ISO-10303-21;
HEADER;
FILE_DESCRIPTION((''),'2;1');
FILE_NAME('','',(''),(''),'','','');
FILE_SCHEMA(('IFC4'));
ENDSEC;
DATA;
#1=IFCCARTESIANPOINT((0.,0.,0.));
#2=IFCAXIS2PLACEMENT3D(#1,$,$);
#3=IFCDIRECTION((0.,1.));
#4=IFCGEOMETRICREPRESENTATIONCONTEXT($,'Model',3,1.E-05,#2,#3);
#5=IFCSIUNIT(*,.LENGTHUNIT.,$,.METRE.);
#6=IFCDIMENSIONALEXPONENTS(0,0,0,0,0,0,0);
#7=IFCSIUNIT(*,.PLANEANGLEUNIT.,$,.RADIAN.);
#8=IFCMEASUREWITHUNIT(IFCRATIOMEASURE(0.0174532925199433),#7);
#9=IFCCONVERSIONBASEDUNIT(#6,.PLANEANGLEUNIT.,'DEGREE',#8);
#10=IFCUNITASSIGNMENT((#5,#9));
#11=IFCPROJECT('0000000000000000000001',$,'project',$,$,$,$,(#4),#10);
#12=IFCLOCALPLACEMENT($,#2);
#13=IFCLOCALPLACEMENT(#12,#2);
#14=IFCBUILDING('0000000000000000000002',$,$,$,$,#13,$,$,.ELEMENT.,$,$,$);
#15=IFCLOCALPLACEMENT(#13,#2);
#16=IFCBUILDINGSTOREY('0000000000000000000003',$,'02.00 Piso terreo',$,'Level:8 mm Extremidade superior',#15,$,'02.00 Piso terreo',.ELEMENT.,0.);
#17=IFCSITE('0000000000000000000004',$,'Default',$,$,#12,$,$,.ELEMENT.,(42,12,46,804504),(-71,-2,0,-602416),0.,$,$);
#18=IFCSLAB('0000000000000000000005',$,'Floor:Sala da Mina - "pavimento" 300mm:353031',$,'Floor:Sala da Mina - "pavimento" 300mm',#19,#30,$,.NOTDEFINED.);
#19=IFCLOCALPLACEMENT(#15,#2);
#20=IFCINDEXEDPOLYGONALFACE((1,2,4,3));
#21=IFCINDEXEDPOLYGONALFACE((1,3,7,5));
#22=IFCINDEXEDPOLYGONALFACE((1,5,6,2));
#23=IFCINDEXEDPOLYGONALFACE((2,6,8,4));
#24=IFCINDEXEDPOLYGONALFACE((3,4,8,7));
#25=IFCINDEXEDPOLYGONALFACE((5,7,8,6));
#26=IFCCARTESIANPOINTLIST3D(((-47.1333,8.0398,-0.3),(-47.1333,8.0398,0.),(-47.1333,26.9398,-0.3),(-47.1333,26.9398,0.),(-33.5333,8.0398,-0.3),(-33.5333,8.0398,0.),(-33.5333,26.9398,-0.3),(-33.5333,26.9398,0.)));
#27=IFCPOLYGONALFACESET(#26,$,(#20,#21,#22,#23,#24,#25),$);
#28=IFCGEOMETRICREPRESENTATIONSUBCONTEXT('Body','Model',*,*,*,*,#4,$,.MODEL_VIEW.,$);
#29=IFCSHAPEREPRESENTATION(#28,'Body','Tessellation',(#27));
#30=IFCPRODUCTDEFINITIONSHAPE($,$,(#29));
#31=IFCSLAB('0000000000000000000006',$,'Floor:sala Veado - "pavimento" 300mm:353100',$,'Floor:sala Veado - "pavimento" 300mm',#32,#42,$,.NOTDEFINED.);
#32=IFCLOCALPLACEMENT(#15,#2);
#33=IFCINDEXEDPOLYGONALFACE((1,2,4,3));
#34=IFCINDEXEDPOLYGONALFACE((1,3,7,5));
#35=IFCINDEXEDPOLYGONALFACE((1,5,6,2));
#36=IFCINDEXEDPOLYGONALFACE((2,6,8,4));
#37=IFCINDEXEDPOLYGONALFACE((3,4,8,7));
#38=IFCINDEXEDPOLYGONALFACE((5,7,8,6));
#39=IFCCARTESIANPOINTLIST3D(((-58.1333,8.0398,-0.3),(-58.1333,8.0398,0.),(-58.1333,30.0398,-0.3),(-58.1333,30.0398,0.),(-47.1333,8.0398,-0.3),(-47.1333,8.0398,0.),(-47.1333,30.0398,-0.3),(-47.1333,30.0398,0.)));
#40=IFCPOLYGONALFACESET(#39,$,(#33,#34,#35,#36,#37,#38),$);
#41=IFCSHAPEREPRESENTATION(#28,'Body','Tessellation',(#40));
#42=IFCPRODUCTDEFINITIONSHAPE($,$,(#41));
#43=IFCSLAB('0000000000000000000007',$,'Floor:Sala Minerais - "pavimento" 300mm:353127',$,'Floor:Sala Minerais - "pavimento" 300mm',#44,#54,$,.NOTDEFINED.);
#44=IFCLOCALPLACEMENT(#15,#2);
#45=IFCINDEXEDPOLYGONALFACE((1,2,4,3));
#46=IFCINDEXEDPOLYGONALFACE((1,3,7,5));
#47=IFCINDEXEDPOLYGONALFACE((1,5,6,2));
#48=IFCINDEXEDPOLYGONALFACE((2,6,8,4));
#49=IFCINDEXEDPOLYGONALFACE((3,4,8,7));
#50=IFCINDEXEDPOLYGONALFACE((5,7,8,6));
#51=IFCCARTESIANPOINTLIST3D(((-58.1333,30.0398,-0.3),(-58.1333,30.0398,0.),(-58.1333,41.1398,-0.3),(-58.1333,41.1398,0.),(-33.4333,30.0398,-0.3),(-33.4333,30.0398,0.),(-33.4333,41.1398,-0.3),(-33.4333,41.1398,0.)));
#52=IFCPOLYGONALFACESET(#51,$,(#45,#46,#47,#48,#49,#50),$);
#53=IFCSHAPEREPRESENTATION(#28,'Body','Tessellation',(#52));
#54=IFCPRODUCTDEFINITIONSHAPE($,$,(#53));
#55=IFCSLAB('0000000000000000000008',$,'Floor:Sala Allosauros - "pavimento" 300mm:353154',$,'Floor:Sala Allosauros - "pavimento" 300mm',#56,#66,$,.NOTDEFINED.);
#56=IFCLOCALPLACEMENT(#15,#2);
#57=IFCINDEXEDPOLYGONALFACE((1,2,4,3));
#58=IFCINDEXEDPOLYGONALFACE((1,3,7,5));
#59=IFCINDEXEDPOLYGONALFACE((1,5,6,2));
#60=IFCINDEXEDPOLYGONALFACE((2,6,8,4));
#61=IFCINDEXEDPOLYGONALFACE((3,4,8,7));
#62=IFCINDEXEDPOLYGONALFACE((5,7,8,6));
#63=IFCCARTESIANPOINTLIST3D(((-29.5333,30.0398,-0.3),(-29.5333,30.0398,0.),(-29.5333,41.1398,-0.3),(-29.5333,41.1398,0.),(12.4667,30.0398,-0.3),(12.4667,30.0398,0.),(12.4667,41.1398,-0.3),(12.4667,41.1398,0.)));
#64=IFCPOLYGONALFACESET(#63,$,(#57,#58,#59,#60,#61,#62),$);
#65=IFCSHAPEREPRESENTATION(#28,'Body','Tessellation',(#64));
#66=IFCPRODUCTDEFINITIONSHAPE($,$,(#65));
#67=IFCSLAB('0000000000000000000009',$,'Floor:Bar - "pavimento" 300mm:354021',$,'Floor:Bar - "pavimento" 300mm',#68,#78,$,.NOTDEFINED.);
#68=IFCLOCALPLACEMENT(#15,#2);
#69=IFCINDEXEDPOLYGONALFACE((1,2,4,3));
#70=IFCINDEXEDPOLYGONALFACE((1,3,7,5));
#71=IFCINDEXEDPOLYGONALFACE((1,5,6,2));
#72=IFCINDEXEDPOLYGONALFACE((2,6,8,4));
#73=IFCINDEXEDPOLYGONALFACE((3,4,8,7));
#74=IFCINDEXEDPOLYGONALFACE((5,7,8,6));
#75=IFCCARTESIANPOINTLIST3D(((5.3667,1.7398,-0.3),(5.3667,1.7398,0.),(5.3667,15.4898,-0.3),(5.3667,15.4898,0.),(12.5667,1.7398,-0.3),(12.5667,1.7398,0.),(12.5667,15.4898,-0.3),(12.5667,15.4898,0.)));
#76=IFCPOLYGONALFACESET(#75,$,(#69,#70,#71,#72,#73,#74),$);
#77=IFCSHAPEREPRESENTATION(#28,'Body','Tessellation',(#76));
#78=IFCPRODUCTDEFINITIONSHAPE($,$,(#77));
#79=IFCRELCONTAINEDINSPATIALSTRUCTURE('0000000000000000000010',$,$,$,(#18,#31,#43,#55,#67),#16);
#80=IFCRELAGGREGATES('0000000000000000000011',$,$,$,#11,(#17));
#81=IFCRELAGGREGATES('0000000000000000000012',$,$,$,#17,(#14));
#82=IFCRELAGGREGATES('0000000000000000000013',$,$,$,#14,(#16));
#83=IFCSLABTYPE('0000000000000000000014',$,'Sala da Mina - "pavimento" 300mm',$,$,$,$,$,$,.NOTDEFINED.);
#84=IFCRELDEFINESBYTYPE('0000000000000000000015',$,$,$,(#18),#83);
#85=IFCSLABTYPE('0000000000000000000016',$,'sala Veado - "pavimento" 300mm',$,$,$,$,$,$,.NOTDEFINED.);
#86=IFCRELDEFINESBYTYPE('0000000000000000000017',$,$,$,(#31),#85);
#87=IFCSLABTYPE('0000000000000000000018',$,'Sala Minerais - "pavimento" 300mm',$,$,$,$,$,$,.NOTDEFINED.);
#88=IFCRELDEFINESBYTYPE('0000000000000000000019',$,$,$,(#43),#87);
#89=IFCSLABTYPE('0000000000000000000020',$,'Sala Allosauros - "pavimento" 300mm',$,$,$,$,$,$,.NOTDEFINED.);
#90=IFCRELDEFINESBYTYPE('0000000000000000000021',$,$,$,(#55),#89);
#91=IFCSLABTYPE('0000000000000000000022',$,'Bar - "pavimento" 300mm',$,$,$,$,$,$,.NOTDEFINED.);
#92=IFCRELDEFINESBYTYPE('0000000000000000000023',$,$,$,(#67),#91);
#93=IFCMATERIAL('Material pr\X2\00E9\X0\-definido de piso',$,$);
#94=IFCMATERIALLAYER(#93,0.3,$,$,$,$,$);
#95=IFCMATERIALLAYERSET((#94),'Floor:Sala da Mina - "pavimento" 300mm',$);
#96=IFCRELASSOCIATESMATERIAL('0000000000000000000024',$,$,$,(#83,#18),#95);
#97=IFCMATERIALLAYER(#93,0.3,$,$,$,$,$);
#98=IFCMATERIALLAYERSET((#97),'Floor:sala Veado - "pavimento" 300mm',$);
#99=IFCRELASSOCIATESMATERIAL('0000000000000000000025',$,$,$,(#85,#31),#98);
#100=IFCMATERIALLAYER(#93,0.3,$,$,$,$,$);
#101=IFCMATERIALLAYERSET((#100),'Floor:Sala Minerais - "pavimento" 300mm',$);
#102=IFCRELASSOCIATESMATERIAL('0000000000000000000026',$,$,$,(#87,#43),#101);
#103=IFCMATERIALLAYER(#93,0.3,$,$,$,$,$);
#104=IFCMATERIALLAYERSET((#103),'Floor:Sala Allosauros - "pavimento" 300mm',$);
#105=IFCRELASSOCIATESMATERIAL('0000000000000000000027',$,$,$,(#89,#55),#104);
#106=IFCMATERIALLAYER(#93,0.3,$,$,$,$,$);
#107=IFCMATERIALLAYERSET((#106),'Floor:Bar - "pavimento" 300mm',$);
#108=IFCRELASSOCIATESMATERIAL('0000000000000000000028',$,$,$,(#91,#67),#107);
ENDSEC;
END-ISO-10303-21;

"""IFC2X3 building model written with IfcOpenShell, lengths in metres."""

from ifc_helpers import new_model, entity, si_unit, converted_unit, direction, frame, frame_2d, origin, origin_2d_with_axis, place, context, subcontext, project, spatial, rectangle, extrude, material, layer, layer_set, layer_usage, type_object, element, save


model = new_model("IFC2X3")

# Units and contexts
model_context = context("Model", 3, precision=1e-05, world=origin(), true_north=direction((0.0, 1.0)))
body_context = subcontext(model_context, "Body", "Model", "MODEL_VIEW")
ifc_project = project(units=[si_unit("LENGTHUNIT", "METRE"), converted_unit("PLANEANGLEUNIT", "DEGREE", entity("IfcRatioMeasure", 0.0174532925199433), si_unit("PLANEANGLEUNIT", "RADIAN"), dimensions=[0, 0, 0, 0, 0, 0, 0])], contexts=[model_context])

# Site, building, storey
site_placement = place(None, origin())
site = spatial("IfcSite", under=ifc_project, at=site_placement, Name="Default", CompositionType="ELEMENT", RefLatitude=(42, 12, 46, 804504), RefLongitude=(-71, -2, 0, -602416), RefElevation=0.0)
building_placement = place(site_placement, origin())
building = spatial("IfcBuilding", under=site, at=building_placement, CompositionType="ELEMENT")
storey_placement = place(building_placement, origin())
storey = spatial("IfcBuildingStorey", under=building, at=storey_placement, Name="02.00 Piso terreo", ObjectType="Level:8 mm Extremidade superior", LongName="02.00 Piso terreo", CompositionType="ELEMENT", Elevation=0.0)

# Slabs
ifc_material = material(Name="Material pré-definido de piso")
ifc_layer_1 = layer(ifc_material, 0.3)
ifc_layer_set_1 = layer_set([ifc_layer_1], Name="Floor:Sala da Mina - \"pavimento\" 300mm")
ifc_layer_usage_1 = layer_usage(ifc_layer_set_1, "AXIS3", "POSITIVE", 0.0)
slab_type_1 = type_object("IfcSlabType", Name="Sala da Mina - \"pavimento\" 300mm", PredefinedType="NOTDEFINED", material=ifc_layer_set_1)
slab_1_placement = place(storey_placement, origin())
element("IfcSlab", 1, at=slab_1_placement, inside=storey, type_object=slab_type_1, material=ifc_layer_usage_1, Name="Floor:Sala da Mina - \"pavimento\" 300mm:353031", ObjectType="Floor:Sala da Mina - \"pavimento\" 300mm", PredefinedType="NOTDEFINED", context=body_context, shape_type="SweptSolid", body=[
    extrude(rectangle(XDim=18.9, YDim=13.6, at=frame_2d((0.0, 0.0), x_axis=(1.0, 0.0))), frame((-40.3333, 17.4898, 0.0), z_axis=(0.0, 0.0, -1.0), x_axis=(0.0, 1.0, 0.0)), (0.0, 0.0, 1.0), 0.3),
])
ifc_layer_2 = layer(ifc_material, 0.3)
ifc_layer_set_2 = layer_set([ifc_layer_2], Name="Floor:sala Veado - \"pavimento\" 300mm")
ifc_layer_usage_2 = layer_usage(ifc_layer_set_2, "AXIS3", "POSITIVE", 0.0)
slab_type_2 = type_object("IfcSlabType", Name="sala Veado - \"pavimento\" 300mm", PredefinedType="NOTDEFINED", material=ifc_layer_set_2)
slab_2_placement = place(storey_placement, origin())
element("IfcSlab", 2, at=slab_2_placement, inside=storey, type_object=slab_type_2, material=ifc_layer_usage_2, Name="Floor:sala Veado - \"pavimento\" 300mm:353100", ObjectType="Floor:sala Veado - \"pavimento\" 300mm", PredefinedType="NOTDEFINED", context=body_context, shape_type="SweptSolid", body=[
    extrude(rectangle(XDim=22.0, YDim=11.0, at=frame_2d((0.0, 0.0), x_axis=(1.0, 0.0))), frame((-52.6333, 19.0398, 0.0), z_axis=(0.0, 0.0, -1.0), x_axis=(0.0, 1.0, 0.0)), (0.0, 0.0, 1.0), 0.3),
])
ifc_layer_3 = layer(ifc_material, 0.3)
ifc_layer_set_3 = layer_set([ifc_layer_3], Name="Floor:Sala Minerais - \"pavimento\" 300mm")
ifc_layer_usage_3 = layer_usage(ifc_layer_set_3, "AXIS3", "POSITIVE", 0.0)
slab_type_3 = type_object("IfcSlabType", Name="Sala Minerais - \"pavimento\" 300mm", PredefinedType="NOTDEFINED", material=ifc_layer_set_3)
slab_3_placement = place(storey_placement, origin())
element("IfcSlab", 3, at=slab_3_placement, inside=storey, type_object=slab_type_3, material=ifc_layer_usage_3, Name="Floor:Sala Minerais - \"pavimento\" 300mm:353127", ObjectType="Floor:Sala Minerais - \"pavimento\" 300mm", PredefinedType="NOTDEFINED", context=body_context, shape_type="SweptSolid", body=[
    extrude(rectangle(XDim=11.1, YDim=24.7, at=frame_2d((0.0, 0.0), x_axis=(1.0, 0.0))), frame((-45.7833, 35.5898, 0.0), z_axis=(0.0, 0.0, -1.0), x_axis=(0.0, 1.0, 0.0)), (0.0, 0.0, 1.0), 0.3),
])
ifc_layer_4 = layer(ifc_material, 0.3)
ifc_layer_set_4 = layer_set([ifc_layer_4], Name="Floor:Sala Allosauros - \"pavimento\" 300mm")
ifc_layer_usage_4 = layer_usage(ifc_layer_set_4, "AXIS3", "POSITIVE", 0.0)
slab_type_4 = type_object("IfcSlabType", Name="Sala Allosauros - \"pavimento\" 300mm", PredefinedType="NOTDEFINED", material=ifc_layer_set_4)
slab_4_placement = place(storey_placement, origin())
element("IfcSlab", 4, at=slab_4_placement, inside=storey, type_object=slab_type_4, material=ifc_layer_usage_4, Name="Floor:Sala Allosauros - \"pavimento\" 300mm:353154", ObjectType="Floor:Sala Allosauros - \"pavimento\" 300mm", PredefinedType="NOTDEFINED", context=body_context, shape_type="SweptSolid", body=[
    extrude(rectangle(XDim=11.1, YDim=42.0, at=frame_2d((0.0, 0.0), x_axis=(1.0, 0.0))), frame((-8.5333, 35.5898, 0.0), z_axis=(0.0, 0.0, -1.0), x_axis=(0.0, 1.0, 0.0)), (0.0, 0.0, 1.0), 0.3),
])
ifc_layer_5 = layer(ifc_material, 0.3)
ifc_layer_set_5 = layer_set([ifc_layer_5], Name="Floor:Bar - \"pavimento\" 300mm")
ifc_layer_usage_5 = layer_usage(ifc_layer_set_5, "AXIS3", "POSITIVE", 0.0)
slab_type_5 = type_object("IfcSlabType", Name="Bar - \"pavimento\" 300mm", PredefinedType="NOTDEFINED", material=ifc_layer_set_5)
slab_5_placement = place(storey_placement, origin())
element("IfcSlab", 5, at=slab_5_placement, inside=storey, type_object=slab_type_5, material=ifc_layer_usage_5, Name="Floor:Bar - \"pavimento\" 300mm:354021", ObjectType="Floor:Bar - \"pavimento\" 300mm", PredefinedType="NOTDEFINED", context=body_context, shape_type="SweptSolid", body=[
    extrude(rectangle(XDim=13.75, YDim=7.2, at=origin_2d_with_axis()), frame((8.9667, 8.6148, 0.0), z_axis=(0.0, 0.0, -1.0), x_axis=(0.0, 1.0, 0.0)), (0.0, 0.0, 1.0), 0.3),
])

save(model, "model.ifc")
